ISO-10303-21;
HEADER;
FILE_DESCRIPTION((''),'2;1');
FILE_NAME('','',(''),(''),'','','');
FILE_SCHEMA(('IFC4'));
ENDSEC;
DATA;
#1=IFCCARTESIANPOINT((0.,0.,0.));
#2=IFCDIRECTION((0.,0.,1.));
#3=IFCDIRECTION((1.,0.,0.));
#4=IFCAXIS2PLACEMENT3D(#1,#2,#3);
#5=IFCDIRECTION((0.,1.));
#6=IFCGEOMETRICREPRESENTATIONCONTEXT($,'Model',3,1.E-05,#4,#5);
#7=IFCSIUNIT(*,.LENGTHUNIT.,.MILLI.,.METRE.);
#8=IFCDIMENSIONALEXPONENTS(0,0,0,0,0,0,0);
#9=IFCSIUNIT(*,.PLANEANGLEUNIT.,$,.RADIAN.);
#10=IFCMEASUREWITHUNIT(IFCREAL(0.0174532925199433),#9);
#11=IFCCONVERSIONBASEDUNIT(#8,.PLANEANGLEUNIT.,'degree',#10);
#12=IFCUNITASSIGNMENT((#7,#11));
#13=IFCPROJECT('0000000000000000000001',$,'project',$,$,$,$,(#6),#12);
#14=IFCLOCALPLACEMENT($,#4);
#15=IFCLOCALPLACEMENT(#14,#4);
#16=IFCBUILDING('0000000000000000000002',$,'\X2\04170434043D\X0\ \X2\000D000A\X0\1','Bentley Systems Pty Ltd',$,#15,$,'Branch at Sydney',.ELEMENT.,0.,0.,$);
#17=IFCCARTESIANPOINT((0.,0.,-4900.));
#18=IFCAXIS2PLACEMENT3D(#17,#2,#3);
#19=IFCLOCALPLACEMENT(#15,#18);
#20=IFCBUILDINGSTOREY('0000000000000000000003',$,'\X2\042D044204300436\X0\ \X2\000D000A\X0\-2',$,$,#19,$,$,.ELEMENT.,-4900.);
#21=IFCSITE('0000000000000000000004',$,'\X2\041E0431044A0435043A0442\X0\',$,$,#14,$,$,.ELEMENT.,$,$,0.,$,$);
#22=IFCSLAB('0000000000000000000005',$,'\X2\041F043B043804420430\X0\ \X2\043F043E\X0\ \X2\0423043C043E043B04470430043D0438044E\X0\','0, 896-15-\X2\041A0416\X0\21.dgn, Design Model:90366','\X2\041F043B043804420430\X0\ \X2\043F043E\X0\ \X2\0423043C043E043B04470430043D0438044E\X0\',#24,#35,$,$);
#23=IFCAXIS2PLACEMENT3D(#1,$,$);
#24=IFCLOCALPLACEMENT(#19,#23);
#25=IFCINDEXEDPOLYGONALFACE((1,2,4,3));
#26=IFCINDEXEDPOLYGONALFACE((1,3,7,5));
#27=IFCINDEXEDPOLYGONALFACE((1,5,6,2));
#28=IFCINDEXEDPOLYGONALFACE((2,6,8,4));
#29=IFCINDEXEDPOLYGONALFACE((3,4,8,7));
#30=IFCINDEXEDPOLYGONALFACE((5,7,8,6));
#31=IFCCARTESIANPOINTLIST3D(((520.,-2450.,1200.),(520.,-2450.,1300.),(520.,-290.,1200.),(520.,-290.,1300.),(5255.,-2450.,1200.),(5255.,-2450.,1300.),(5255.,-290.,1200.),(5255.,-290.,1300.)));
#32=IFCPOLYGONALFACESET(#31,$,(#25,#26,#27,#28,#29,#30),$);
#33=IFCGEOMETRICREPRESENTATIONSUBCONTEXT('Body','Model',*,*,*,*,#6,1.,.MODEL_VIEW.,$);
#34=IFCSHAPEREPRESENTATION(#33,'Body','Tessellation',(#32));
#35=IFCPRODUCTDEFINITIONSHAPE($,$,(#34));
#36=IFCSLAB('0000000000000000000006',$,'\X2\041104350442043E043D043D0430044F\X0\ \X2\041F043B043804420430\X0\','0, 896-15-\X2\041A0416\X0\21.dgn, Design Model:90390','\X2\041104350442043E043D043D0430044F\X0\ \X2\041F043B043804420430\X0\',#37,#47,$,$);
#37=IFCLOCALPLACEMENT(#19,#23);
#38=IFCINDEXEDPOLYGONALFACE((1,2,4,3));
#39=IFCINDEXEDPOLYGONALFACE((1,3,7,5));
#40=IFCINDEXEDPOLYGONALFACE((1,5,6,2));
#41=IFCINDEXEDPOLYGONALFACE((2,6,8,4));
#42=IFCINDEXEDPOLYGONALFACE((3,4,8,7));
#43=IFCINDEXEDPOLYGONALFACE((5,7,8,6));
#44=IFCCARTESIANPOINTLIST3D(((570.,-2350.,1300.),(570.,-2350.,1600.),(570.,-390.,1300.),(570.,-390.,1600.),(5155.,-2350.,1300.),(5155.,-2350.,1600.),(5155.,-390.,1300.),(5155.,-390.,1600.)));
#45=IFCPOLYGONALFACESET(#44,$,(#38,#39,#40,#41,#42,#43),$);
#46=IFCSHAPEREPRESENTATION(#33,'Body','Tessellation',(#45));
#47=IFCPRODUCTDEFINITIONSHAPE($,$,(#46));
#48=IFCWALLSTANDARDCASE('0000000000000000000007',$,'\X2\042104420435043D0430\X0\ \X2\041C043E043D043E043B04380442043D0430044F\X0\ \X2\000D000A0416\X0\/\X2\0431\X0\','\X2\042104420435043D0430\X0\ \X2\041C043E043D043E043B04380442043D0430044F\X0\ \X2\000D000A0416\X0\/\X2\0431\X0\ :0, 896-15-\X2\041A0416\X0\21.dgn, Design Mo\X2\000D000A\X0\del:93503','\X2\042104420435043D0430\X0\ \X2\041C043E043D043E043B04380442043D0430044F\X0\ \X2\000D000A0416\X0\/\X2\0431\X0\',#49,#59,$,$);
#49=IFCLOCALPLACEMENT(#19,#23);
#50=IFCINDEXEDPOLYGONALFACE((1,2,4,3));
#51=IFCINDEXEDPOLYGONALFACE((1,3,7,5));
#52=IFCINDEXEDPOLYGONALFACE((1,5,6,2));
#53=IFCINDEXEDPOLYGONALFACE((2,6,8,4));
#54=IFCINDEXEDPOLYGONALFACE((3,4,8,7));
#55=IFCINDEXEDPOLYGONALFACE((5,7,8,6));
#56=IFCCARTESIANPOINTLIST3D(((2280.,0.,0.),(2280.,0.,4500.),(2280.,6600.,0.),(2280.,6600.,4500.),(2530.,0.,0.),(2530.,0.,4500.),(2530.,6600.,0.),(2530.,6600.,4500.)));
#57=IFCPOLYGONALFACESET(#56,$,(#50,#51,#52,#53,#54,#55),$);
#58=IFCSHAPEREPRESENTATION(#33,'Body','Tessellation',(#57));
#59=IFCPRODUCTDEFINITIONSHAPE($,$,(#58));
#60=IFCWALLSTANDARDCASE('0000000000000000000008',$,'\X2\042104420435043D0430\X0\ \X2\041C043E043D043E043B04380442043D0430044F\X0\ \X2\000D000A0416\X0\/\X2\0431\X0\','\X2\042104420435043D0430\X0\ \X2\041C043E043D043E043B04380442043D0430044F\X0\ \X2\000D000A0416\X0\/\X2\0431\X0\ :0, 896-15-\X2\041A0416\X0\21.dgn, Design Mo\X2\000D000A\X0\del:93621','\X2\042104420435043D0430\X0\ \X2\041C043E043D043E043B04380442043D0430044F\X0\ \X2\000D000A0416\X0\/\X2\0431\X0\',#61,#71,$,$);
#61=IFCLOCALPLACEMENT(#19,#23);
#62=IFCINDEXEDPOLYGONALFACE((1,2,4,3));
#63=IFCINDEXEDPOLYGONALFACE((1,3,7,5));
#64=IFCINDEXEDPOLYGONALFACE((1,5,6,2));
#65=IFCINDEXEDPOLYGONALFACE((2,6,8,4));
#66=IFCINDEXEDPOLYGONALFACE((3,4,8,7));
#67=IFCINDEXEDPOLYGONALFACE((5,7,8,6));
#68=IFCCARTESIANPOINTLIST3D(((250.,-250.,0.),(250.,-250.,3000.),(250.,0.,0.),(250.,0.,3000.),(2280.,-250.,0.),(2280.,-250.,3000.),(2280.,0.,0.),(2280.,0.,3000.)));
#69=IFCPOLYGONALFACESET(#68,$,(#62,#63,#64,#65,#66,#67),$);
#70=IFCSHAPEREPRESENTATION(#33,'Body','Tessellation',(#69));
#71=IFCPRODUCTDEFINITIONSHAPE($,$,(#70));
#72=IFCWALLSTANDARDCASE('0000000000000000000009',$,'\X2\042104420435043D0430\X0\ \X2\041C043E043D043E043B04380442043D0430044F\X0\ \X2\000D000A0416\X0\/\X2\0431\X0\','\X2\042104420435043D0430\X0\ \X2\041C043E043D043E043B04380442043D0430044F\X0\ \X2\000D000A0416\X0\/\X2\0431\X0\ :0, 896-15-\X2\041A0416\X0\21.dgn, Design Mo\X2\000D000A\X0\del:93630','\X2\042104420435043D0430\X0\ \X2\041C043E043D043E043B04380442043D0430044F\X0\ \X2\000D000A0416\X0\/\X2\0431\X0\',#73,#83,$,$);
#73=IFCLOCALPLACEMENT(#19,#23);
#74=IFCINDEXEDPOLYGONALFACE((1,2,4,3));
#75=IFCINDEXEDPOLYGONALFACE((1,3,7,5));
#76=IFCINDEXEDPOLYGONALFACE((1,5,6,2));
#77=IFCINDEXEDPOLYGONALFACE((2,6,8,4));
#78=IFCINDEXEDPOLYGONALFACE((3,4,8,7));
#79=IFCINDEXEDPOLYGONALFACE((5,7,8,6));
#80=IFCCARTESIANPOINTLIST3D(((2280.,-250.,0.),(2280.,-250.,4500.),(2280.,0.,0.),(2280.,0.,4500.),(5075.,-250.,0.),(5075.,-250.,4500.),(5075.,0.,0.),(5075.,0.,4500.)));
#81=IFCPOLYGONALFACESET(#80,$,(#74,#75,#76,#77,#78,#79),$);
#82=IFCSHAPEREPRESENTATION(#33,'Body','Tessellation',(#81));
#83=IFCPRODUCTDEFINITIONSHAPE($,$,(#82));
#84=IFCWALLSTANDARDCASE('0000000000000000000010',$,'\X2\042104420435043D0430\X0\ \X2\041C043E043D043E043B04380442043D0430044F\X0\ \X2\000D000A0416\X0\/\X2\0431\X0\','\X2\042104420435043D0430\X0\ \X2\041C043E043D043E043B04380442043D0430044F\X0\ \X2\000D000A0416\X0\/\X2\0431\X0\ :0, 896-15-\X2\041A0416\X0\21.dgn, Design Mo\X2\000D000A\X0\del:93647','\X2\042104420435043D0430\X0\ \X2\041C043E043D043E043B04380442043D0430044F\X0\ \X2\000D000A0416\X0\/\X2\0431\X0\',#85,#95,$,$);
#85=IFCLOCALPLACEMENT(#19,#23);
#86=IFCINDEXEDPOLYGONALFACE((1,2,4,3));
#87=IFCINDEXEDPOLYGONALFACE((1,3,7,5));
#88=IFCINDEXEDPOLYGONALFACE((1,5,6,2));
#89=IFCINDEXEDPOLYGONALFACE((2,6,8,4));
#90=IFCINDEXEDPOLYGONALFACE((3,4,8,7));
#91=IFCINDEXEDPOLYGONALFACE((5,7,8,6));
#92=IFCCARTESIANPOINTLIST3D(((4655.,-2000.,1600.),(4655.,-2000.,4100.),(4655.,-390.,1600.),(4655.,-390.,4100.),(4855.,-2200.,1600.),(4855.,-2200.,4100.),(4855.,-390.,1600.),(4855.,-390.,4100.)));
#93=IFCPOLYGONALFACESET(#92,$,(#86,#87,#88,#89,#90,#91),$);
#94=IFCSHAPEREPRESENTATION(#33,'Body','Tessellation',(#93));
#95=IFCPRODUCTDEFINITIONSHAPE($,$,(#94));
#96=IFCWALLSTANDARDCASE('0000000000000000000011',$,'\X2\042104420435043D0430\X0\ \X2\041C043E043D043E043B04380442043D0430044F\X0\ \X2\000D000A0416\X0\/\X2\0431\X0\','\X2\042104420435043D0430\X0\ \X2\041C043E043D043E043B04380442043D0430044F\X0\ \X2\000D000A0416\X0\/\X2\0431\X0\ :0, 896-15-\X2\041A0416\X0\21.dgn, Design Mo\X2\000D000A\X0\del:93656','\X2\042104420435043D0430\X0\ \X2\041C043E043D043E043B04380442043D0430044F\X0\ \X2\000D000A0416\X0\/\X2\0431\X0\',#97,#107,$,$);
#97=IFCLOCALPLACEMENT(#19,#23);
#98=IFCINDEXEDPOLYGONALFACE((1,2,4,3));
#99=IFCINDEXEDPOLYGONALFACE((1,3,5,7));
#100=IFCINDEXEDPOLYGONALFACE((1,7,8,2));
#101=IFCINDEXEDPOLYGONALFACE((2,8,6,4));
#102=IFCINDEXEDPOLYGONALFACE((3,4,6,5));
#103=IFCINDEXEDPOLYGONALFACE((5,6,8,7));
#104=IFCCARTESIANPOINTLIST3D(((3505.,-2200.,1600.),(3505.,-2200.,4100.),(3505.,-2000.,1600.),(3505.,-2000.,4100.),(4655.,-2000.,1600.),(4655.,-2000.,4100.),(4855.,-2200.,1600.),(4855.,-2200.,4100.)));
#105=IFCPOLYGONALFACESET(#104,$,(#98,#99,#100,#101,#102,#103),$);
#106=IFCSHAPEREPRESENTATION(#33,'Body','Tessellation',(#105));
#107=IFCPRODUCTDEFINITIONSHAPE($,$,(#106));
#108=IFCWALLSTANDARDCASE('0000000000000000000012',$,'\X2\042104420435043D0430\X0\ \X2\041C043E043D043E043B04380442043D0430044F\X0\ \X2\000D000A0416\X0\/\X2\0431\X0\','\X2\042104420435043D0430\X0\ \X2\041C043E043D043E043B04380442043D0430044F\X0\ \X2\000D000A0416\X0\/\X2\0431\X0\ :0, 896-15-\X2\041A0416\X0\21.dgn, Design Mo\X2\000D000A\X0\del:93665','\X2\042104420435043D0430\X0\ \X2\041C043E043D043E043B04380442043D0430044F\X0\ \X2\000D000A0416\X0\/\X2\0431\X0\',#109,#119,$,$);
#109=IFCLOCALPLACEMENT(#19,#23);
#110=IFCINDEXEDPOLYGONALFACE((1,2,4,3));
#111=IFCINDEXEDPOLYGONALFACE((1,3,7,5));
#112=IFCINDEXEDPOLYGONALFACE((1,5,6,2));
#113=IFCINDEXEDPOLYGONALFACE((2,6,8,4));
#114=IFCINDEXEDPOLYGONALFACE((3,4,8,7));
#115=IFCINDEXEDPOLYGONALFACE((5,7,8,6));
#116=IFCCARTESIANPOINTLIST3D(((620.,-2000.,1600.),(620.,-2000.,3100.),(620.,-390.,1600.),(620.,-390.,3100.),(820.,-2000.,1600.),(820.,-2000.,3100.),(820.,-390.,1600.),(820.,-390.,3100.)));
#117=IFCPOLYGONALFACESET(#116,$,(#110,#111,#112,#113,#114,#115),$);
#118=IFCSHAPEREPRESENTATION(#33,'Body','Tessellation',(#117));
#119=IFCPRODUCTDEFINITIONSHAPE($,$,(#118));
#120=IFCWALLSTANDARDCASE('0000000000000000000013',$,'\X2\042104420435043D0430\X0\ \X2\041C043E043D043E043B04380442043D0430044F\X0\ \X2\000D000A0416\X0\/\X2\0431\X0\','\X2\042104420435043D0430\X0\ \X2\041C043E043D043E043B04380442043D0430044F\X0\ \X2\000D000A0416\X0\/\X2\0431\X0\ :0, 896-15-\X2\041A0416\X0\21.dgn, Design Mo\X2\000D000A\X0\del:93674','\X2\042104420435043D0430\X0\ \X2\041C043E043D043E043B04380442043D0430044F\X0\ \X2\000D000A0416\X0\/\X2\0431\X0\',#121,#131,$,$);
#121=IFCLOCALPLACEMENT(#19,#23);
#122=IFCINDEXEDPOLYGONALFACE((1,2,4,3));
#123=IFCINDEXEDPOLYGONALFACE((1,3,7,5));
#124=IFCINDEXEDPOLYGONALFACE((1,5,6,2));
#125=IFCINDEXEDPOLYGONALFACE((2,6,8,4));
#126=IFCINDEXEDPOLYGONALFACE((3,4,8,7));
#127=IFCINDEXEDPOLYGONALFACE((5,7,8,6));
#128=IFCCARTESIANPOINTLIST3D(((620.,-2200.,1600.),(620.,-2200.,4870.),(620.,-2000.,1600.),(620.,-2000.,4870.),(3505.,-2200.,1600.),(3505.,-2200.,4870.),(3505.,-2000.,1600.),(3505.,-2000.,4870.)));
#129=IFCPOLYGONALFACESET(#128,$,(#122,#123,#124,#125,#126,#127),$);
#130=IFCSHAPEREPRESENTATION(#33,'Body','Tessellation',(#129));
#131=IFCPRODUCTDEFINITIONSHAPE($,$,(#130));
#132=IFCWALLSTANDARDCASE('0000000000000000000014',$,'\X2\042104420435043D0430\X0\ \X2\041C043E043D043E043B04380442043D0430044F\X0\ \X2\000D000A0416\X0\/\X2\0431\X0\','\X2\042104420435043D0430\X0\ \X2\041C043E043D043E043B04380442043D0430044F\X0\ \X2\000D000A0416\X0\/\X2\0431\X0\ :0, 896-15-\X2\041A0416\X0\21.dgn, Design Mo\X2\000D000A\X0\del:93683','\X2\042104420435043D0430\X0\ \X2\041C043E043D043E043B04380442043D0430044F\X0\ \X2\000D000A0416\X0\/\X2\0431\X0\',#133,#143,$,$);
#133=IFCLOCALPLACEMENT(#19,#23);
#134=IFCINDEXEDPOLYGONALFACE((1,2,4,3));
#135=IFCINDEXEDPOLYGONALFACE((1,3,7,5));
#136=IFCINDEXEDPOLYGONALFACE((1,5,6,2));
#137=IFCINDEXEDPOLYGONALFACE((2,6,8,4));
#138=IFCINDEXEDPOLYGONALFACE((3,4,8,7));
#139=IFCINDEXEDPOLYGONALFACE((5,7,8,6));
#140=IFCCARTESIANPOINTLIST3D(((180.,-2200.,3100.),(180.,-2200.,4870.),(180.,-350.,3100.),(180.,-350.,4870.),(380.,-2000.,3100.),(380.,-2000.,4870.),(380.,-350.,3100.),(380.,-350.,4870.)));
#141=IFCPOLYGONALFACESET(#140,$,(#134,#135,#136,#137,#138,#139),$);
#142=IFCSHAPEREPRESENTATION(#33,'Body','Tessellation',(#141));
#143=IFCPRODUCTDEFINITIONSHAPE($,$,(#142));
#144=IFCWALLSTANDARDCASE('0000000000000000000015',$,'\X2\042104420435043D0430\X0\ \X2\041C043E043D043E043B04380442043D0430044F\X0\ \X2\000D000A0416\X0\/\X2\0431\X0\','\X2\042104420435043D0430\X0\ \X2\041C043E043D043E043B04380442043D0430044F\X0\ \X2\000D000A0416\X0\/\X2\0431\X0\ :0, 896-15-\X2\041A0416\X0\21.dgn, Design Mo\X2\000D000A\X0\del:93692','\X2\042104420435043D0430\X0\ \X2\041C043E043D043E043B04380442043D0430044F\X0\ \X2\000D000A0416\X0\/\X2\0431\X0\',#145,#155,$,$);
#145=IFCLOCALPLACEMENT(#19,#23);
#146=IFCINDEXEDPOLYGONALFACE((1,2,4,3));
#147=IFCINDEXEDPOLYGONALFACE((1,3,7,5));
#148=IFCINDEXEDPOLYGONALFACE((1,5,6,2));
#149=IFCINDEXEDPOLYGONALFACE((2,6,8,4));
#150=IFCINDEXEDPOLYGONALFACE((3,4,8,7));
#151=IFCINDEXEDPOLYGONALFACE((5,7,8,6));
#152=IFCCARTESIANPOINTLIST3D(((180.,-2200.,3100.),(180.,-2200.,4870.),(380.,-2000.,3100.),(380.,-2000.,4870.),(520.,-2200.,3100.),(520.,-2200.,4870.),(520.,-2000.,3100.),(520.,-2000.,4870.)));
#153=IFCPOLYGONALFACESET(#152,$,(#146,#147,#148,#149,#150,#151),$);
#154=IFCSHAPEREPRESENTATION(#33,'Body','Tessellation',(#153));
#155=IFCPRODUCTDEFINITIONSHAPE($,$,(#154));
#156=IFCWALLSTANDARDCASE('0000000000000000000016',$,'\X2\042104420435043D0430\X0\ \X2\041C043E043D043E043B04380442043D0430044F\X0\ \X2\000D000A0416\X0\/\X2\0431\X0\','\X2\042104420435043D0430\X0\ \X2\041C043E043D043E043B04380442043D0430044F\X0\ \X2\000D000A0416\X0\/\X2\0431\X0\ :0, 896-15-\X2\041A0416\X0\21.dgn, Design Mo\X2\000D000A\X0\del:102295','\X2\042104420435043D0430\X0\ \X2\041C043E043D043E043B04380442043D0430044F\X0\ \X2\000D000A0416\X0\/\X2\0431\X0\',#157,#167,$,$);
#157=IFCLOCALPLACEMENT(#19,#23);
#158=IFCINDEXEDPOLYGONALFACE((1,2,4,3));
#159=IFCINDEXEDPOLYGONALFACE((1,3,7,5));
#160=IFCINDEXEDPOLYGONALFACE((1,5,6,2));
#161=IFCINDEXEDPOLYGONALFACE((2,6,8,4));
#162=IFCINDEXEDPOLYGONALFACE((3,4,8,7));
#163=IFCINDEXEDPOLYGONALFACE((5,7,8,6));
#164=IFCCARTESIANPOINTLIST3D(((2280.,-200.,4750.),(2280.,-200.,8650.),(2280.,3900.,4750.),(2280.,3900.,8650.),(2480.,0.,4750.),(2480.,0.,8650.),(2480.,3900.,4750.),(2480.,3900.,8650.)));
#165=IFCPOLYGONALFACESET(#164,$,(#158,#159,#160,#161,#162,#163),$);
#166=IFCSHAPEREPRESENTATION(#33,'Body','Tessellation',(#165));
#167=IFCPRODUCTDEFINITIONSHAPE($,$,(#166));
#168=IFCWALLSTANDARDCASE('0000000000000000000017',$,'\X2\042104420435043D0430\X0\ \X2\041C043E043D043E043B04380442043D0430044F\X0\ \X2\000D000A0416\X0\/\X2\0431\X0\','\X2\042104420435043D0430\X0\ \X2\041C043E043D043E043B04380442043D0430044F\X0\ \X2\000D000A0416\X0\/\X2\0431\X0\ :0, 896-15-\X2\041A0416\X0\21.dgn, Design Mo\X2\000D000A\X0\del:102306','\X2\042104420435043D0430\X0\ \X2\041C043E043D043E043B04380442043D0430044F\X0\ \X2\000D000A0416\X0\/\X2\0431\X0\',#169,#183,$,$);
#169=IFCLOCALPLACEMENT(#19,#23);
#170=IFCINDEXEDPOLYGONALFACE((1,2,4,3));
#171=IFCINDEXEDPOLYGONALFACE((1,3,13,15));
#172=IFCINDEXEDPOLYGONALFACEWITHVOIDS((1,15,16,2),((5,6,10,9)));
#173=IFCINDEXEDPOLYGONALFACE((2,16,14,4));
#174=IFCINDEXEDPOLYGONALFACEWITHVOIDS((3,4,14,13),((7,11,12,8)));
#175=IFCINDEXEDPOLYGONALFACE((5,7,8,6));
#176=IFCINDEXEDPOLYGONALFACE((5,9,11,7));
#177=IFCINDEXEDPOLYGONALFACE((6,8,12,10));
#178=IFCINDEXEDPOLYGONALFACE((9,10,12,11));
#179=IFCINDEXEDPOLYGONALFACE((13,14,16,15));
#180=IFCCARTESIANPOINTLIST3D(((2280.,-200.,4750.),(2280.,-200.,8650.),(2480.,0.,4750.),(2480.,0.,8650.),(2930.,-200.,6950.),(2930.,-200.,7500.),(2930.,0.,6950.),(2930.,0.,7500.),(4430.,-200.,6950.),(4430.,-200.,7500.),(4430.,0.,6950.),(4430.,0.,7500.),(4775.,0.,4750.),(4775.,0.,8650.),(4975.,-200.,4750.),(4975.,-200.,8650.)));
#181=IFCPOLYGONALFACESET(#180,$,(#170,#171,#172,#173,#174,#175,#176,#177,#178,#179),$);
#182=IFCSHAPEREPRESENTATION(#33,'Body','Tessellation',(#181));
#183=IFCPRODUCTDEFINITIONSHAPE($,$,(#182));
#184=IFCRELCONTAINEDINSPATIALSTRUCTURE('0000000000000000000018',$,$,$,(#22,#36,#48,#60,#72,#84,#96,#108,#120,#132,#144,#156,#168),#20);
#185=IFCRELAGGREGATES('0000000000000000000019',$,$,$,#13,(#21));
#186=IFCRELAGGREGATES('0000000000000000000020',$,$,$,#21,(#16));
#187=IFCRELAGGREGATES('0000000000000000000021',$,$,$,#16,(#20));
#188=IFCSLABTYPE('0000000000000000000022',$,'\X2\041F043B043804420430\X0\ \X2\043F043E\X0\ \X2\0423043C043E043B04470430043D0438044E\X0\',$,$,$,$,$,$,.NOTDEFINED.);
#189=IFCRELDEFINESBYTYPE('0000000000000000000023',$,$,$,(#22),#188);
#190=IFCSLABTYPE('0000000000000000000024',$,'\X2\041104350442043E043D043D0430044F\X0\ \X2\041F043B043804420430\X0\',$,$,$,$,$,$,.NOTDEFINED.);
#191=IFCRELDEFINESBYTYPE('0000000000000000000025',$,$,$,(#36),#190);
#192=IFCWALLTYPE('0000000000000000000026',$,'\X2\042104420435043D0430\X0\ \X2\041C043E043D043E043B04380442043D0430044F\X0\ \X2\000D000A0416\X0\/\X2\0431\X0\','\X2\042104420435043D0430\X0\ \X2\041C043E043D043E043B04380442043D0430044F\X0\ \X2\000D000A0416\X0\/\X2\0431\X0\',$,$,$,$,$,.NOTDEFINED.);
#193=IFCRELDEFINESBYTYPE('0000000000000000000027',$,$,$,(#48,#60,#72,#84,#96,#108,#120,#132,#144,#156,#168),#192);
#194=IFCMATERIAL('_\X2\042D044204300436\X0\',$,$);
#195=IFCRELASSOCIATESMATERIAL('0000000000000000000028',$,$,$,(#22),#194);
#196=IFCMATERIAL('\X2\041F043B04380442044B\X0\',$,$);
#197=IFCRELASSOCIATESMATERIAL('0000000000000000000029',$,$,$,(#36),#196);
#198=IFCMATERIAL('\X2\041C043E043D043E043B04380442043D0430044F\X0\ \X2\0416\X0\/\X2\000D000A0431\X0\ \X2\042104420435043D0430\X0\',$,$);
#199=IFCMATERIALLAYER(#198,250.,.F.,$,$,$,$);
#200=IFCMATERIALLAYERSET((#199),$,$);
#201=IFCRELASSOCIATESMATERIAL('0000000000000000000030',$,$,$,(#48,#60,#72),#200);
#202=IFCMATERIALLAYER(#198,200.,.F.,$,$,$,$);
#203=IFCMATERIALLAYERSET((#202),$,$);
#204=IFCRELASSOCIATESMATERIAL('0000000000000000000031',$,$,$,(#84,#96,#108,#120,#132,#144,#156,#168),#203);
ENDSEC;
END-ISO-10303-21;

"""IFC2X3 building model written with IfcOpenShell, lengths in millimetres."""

from ifc_helpers import new_model, entity, si_unit, converted_unit, direction, frame, frame_2d, origin_with_axes, place, context, subcontext, project, spatial, polyline, rectangle, outline, extrude, material, layer, layer_set, layer_usage, type_object, element, save


model = new_model("IFC2X3")

# Units and contexts
model_context = context("Model", 3, precision=1e-05, world=origin_with_axes(), true_north=direction((0.0, 1.0)))
body_context = subcontext(model_context, "Body", "Model", "MODEL_VIEW", scale=1.0)
ifc_project = project(units=[si_unit("LENGTHUNIT", "METRE", prefix="MILLI"), converted_unit("PLANEANGLEUNIT", "degree", entity("IfcReal", 0.0174532925199433), si_unit("PLANEANGLEUNIT", "RADIAN"), dimensions=[0, 0, 0, 0, 0, 0, 0])], contexts=[model_context])

# Site, building, storey
site_placement = place(None, origin_with_axes())
site = spatial("IfcSite", under=ifc_project, at=site_placement, Name="Объект", CompositionType="ELEMENT", RefElevation=0.0)
building_placement = place(site_placement, origin_with_axes())
building = spatial("IfcBuilding", under=site, at=building_placement, Name="Здн \r\n1", Description="Bentley Systems Pty Ltd", LongName="Branch at Sydney", CompositionType="ELEMENT", ElevationOfRefHeight=0.0, ElevationOfTerrain=0.0)
storey_placement = place(building_placement, frame((0.0, 0.0, -4900.0), z_axis=(0.0, 0.0, 1.0), x_axis=(1.0, 0.0, 0.0)))
storey = spatial("IfcBuildingStorey", under=building, at=storey_placement, Name="Этаж \r\n-2", CompositionType="ELEMENT", Elevation=-4900.0)

# Slabs
ifc_material_1 = material(Name="_Этаж")
slab_type_1 = type_object("IfcSlabType", Name="Плита по Умолчанию", PredefinedType="NOTDEFINED")
slab_1_placement = place(storey_placement, frame((5255.0, -290.0, 1300.0), z_axis=(0.0, 0.0, -1.0), x_axis=(0.0, -1.0, 0.0)))
element("IfcSlab", 1, at=slab_1_placement, inside=storey, type_object=slab_type_1, material=ifc_material_1, Name="Плита по Умолчанию", Description="0, 896-15-КЖ21.dgn, Design Model:90366", ObjectType="Плита по Умолчанию", context=body_context, shape_type="SweptSolid", body=[
    extrude(rectangle(XDim=2160.0, YDim=4735.0, at=frame_2d((1080.0, 2367.5), x_axis=(1.0, 0.0))), origin_with_axes(), (0.0, 0.0, 1.0), 100.0),
])
ifc_material_2 = material(Name="Плиты")
slab_type_2 = type_object("IfcSlabType", Name="Бетонная Плита", PredefinedType="NOTDEFINED")
slab_2_placement = place(storey_placement, frame((570.0, -390.0, 1600.0), z_axis=(0.0, 0.0, -1.0), x_axis=(1.0, 0.0, 0.0)))
element("IfcSlab", 2, at=slab_2_placement, inside=storey, type_object=slab_type_2, material=ifc_material_2, Name="Бетонная Плита", Description="0, 896-15-КЖ21.dgn, Design Model:90390", ObjectType="Бетонная Плита", context=body_context, shape_type="SweptSolid", body=[
    extrude(rectangle(XDim=4585.0, YDim=1960.0, at=frame_2d((2292.5, 980.0), x_axis=(1.0, 0.0))), origin_with_axes(), (0.0, 0.0, 1.0), 300.0),
])

# Walls
ifc_material_3 = material(Name="Монолитная Ж/\r\nб Стена")
ifc_layer_1 = layer(ifc_material_3, 250.0, ventilated=False)
ifc_layer_set_1 = layer_set([ifc_layer_1])
ifc_layer_usage_1 = layer_usage(ifc_layer_set_1, "AXIS2", "POSITIVE", 0.0)
wall_type = type_object("IfcWallType", Name="Стена Монолитная \r\nЖ/б", Description="Стена Монолитная \r\nЖ/б", PredefinedType="NOTDEFINED")
wall_1_placement = place(storey_placement, frame((2530.0, 0.0, 0.0), z_axis=(0.0, 0.0, 1.0), x_axis=(0.0, 1.0, 0.0)))
element("IfcWallStandardCase", 3, at=wall_1_placement, inside=storey, type_object=wall_type, material=ifc_layer_usage_1, Name="Стена Монолитная \r\nЖ/б", Description="Стена Монолитная \r\nЖ/б :0, 896-15-КЖ21.dgn, Design Mo\r\ndel:93503", ObjectType="Стена Монолитная \r\nЖ/б", context=body_context, shape_type="SweptSolid", body=[
    extrude(rectangle(XDim=250.0, YDim=6600.0, at=frame_2d((3300.0, 125.0), x_axis=(0.0, -1.0))), origin_with_axes(), (0.0, 0.0, 1.0), 4500.0),
])
wall_2_placement = place(storey_placement, frame((250.0, -250.0, 0.0), z_axis=(0.0, 0.0, 1.0), x_axis=(1.0, 0.0, 0.0)))
element("IfcWallStandardCase", 4, at=wall_2_placement, inside=storey, type_object=wall_type, material=ifc_layer_usage_1, Name="Стена Монолитная \r\nЖ/б", Description="Стена Монолитная \r\nЖ/б :0, 896-15-КЖ21.dgn, Design Mo\r\ndel:93621", ObjectType="Стена Монолитная \r\nЖ/б", context=body_context, shape_type="SweptSolid", body=[
    extrude(rectangle(XDim=2030.0, YDim=250.0, at=frame_2d((1015.0, 125.0), x_axis=(1.0, 0.0))), origin_with_axes(), (0.0, 0.0, 1.0), 3000.0),
])
wall_3_placement = place(storey_placement, frame((2280.0, -250.0, 0.0), z_axis=(0.0, 0.0, 1.0), x_axis=(1.0, 0.0, 0.0)))
element("IfcWallStandardCase", 5, at=wall_3_placement, inside=storey, type_object=wall_type, material=ifc_layer_usage_1, Name="Стена Монолитная \r\nЖ/б", Description="Стена Монолитная \r\nЖ/б :0, 896-15-КЖ21.dgn, Design Mo\r\ndel:93630", ObjectType="Стена Монолитная \r\nЖ/б", context=body_context, shape_type="SweptSolid", body=[
    extrude(rectangle(XDim=2795.0, YDim=250.0, at=frame_2d((1397.5, 125.0), x_axis=(1.0, 0.0))), origin_with_axes(), (0.0, 0.0, 1.0), 4500.0),
])
ifc_layer_2 = layer(ifc_material_3, 200.0, ventilated=False)
ifc_layer_set_2 = layer_set([ifc_layer_2])
ifc_layer_usage_2 = layer_usage(ifc_layer_set_2, "AXIS2", "POSITIVE", 0.0)
wall_4_placement = place(storey_placement, frame((4655.0, -390.0, 1600.0), z_axis=(0.0, 0.0, 1.0), x_axis=(0.0, -1.0, 0.0)))
element("IfcWallStandardCase", 6, at=wall_4_placement, inside=storey, type_object=wall_type, material=ifc_layer_usage_2, Name="Стена Монолитная \r\nЖ/б", Description="Стена Монолитная \r\nЖ/б :0, 896-15-КЖ21.dgn, Design Mo\r\ndel:93647", ObjectType="Стена Монолитная \r\nЖ/б", context=body_context, shape_type="SweptSolid", body=[
    extrude(outline(polyline([(1810.0, 200.0), (0.0, 200.0), (0.0, 0.0), (1610.0, 0.0), (1810.0, 200.0)])), origin_with_axes(), (0.0, 0.0, 1.0), 2500.0),
])
wall_5_placement = place(storey_placement, frame((4655.0, -2000.0, 1600.0), z_axis=(0.0, 0.0, 1.0), x_axis=(-1.0, 0.0, 0.0)))
element("IfcWallStandardCase", 7, at=wall_5_placement, inside=storey, type_object=wall_type, material=ifc_layer_usage_2, Name="Стена Монолитная \r\nЖ/б", Description="Стена Монолитная \r\nЖ/б :0, 896-15-КЖ21.dgn, Design Mo\r\ndel:93656", ObjectType="Стена Монолитная \r\nЖ/б", context=body_context, shape_type="SweptSolid", body=[
    extrude(outline(polyline([(-200.0, 200.0), (0.0, 0.0), (1150.0, 0.0), (1150.0, 200.0), (-200.0, 200.0)])), origin_with_axes(), (0.0, 0.0, 1.0), 2500.0),
])
wall_6_placement = place(storey_placement, frame((620.0, -390.0, 1600.0), z_axis=(0.0, 0.0, 1.0), x_axis=(0.0, -1.0, 0.0)))
element("IfcWallStandardCase", 8, at=wall_6_placement, inside=storey, type_object=wall_type, material=ifc_layer_usage_2, Name="Стена Монолитная \r\nЖ/б", Description="Стена Монолитная \r\nЖ/б :0, 896-15-КЖ21.dgn, Design Mo\r\ndel:93665", ObjectType="Стена Монолитная \r\nЖ/б", context=body_context, shape_type="SweptSolid", body=[
    extrude(rectangle(XDim=1610.0, YDim=200.0, at=frame_2d((805.0, 100.0), x_axis=(-1.0, 0.0))), origin_with_axes(), (0.0, 0.0, 1.0), 1500.0),
])
wall_7_placement = place(storey_placement, frame((620.0, -2200.0, 1600.0), z_axis=(0.0, 0.0, 1.0), x_axis=(1.0, 0.0, 0.0)))
element("IfcWallStandardCase", 9, at=wall_7_placement, inside=storey, type_object=wall_type, material=ifc_layer_usage_2, Name="Стена Монолитная \r\nЖ/б", Description="Стена Монолитная \r\nЖ/б :0, 896-15-КЖ21.dgn, Design Mo\r\ndel:93674", ObjectType="Стена Монолитная \r\nЖ/б", context=body_context, shape_type="SweptSolid", body=[
    extrude(rectangle(XDim=2885.0, YDim=200.0, at=frame_2d((1442.5, 100.0), x_axis=(1.0, 0.0))), origin_with_axes(), (0.0, 0.0, 1.0), 3270.0),
])
wall_8_placement = place(storey_placement, frame((180.0, -350.0, 3100.0), z_axis=(0.0, 0.0, 1.0), x_axis=(0.0, -1.0, 0.0)))
element("IfcWallStandardCase", 10, at=wall_8_placement, inside=storey, type_object=wall_type, material=ifc_layer_usage_2, Name="Стена Монолитная \r\nЖ/б", Description="Стена Монолитная \r\nЖ/б :0, 896-15-КЖ21.dgn, Design Mo\r\ndel:93683", ObjectType="Стена Монолитная \r\nЖ/б", context=body_context, shape_type="SweptSolid", body=[
    extrude(outline(polyline([(1650.0, 200.0), (0.0, 200.0), (0.0, 0.0), (1850.0, 0.0), (1650.0, 200.0)])), origin_with_axes(), (0.0, 0.0, 1.0), 1770.0),
])
wall_9_placement = place(storey_placement, frame((180.0, -2200.0, 3100.0), z_axis=(0.0, 0.0, 1.0), x_axis=(1.0, 0.0, 0.0)))
element("IfcWallStandardCase", 11, at=wall_9_placement, inside=storey, type_object=wall_type, material=ifc_layer_usage_2, Name="Стена Монолитная \r\nЖ/б", Description="Стена Монолитная \r\nЖ/б :0, 896-15-КЖ21.dgn, Design Mo\r\ndel:93692", ObjectType="Стена Монолитная \r\nЖ/б", context=body_context, shape_type="SweptSolid", body=[
    extrude(outline(polyline([(200.0, 200.0), (0.0, 0.0), (340.0, 0.0), (340.0, 200.0), (200.0, 200.0)])), origin_with_axes(), (0.0, 0.0, 1.0), 1770.0),
])
wall_10_placement = place(storey_placement, frame((2280.0, -200.0, 4750.0), z_axis=(0.0, 0.0, 1.0), x_axis=(0.0, 1.0, 0.0)))
element("IfcWallStandardCase", 12, at=wall_10_placement, inside=storey, type_object=wall_type, material=ifc_layer_usage_2, Name="Стена Монолитная \r\nЖ/б", Description="Стена Монолитная \r\nЖ/б :0, 896-15-КЖ21.dgn, Design Mo\r\ndel:102295", ObjectType="Стена Монолитная \r\nЖ/б", context=body_context, shape_type="SweptSolid", body=[
    extrude(outline(polyline([(0.0, 0.0), (200.0, -200.0), (4100.0, -200.0), (4100.0, 0.0), (0.0, 0.0)])), origin_with_axes(), (0.0, 0.0, 1.0), 3900.0),
])

# Wall, opening
wall_11_placement = place(storey_placement, frame((2280.0, -200.0, 4750.0), z_axis=(0.0, 0.0, 1.0), x_axis=(1.0, 0.0, 0.0)))
wall_11 = element("IfcWallStandardCase", 13, at=wall_11_placement, inside=storey, type_object=wall_type, material=ifc_layer_usage_2, Name="Стена Монолитная \r\nЖ/б", Description="Стена Монолитная \r\nЖ/б :0, 896-15-КЖ21.dgn, Design Mo\r\ndel:102306", ObjectType="Стена Монолитная \r\nЖ/б", context=body_context, shape_type="SweptSolid", body=[
    extrude(outline(polyline([(2495.0, 200.0), (200.0, 200.0), (0.0, 0.0), (2695.0, 0.0), (2495.0, 200.0)])), origin_with_axes(), (0.0, 0.0, 1.0), 3900.0),
])
opening_placement = place(wall_11_placement, frame((650.0, 0.0, 2200.0), z_axis=(0.0, 0.0, 1.0), x_axis=(1.0, 0.0, 0.0)))
element("IfcOpeningElement", 14, at=opening_placement, cuts=wall_11, ObjectType="Opening", context=body_context, shape_type="SweptSolid", body=[
    extrude(rectangle(XDim=550.0, YDim=1500.0, at=frame_2d((-750.0, 275.0), x_axis=(0.0, -1.0))), frame((0.0, 0.0, 0.0), z_axis=(0.0, 1.0, 0.0), x_axis=(-1.0, 0.0, 0.0)), (0.0, 0.0, 1.0), 200.0),
])

save(model, "model.ifc")
